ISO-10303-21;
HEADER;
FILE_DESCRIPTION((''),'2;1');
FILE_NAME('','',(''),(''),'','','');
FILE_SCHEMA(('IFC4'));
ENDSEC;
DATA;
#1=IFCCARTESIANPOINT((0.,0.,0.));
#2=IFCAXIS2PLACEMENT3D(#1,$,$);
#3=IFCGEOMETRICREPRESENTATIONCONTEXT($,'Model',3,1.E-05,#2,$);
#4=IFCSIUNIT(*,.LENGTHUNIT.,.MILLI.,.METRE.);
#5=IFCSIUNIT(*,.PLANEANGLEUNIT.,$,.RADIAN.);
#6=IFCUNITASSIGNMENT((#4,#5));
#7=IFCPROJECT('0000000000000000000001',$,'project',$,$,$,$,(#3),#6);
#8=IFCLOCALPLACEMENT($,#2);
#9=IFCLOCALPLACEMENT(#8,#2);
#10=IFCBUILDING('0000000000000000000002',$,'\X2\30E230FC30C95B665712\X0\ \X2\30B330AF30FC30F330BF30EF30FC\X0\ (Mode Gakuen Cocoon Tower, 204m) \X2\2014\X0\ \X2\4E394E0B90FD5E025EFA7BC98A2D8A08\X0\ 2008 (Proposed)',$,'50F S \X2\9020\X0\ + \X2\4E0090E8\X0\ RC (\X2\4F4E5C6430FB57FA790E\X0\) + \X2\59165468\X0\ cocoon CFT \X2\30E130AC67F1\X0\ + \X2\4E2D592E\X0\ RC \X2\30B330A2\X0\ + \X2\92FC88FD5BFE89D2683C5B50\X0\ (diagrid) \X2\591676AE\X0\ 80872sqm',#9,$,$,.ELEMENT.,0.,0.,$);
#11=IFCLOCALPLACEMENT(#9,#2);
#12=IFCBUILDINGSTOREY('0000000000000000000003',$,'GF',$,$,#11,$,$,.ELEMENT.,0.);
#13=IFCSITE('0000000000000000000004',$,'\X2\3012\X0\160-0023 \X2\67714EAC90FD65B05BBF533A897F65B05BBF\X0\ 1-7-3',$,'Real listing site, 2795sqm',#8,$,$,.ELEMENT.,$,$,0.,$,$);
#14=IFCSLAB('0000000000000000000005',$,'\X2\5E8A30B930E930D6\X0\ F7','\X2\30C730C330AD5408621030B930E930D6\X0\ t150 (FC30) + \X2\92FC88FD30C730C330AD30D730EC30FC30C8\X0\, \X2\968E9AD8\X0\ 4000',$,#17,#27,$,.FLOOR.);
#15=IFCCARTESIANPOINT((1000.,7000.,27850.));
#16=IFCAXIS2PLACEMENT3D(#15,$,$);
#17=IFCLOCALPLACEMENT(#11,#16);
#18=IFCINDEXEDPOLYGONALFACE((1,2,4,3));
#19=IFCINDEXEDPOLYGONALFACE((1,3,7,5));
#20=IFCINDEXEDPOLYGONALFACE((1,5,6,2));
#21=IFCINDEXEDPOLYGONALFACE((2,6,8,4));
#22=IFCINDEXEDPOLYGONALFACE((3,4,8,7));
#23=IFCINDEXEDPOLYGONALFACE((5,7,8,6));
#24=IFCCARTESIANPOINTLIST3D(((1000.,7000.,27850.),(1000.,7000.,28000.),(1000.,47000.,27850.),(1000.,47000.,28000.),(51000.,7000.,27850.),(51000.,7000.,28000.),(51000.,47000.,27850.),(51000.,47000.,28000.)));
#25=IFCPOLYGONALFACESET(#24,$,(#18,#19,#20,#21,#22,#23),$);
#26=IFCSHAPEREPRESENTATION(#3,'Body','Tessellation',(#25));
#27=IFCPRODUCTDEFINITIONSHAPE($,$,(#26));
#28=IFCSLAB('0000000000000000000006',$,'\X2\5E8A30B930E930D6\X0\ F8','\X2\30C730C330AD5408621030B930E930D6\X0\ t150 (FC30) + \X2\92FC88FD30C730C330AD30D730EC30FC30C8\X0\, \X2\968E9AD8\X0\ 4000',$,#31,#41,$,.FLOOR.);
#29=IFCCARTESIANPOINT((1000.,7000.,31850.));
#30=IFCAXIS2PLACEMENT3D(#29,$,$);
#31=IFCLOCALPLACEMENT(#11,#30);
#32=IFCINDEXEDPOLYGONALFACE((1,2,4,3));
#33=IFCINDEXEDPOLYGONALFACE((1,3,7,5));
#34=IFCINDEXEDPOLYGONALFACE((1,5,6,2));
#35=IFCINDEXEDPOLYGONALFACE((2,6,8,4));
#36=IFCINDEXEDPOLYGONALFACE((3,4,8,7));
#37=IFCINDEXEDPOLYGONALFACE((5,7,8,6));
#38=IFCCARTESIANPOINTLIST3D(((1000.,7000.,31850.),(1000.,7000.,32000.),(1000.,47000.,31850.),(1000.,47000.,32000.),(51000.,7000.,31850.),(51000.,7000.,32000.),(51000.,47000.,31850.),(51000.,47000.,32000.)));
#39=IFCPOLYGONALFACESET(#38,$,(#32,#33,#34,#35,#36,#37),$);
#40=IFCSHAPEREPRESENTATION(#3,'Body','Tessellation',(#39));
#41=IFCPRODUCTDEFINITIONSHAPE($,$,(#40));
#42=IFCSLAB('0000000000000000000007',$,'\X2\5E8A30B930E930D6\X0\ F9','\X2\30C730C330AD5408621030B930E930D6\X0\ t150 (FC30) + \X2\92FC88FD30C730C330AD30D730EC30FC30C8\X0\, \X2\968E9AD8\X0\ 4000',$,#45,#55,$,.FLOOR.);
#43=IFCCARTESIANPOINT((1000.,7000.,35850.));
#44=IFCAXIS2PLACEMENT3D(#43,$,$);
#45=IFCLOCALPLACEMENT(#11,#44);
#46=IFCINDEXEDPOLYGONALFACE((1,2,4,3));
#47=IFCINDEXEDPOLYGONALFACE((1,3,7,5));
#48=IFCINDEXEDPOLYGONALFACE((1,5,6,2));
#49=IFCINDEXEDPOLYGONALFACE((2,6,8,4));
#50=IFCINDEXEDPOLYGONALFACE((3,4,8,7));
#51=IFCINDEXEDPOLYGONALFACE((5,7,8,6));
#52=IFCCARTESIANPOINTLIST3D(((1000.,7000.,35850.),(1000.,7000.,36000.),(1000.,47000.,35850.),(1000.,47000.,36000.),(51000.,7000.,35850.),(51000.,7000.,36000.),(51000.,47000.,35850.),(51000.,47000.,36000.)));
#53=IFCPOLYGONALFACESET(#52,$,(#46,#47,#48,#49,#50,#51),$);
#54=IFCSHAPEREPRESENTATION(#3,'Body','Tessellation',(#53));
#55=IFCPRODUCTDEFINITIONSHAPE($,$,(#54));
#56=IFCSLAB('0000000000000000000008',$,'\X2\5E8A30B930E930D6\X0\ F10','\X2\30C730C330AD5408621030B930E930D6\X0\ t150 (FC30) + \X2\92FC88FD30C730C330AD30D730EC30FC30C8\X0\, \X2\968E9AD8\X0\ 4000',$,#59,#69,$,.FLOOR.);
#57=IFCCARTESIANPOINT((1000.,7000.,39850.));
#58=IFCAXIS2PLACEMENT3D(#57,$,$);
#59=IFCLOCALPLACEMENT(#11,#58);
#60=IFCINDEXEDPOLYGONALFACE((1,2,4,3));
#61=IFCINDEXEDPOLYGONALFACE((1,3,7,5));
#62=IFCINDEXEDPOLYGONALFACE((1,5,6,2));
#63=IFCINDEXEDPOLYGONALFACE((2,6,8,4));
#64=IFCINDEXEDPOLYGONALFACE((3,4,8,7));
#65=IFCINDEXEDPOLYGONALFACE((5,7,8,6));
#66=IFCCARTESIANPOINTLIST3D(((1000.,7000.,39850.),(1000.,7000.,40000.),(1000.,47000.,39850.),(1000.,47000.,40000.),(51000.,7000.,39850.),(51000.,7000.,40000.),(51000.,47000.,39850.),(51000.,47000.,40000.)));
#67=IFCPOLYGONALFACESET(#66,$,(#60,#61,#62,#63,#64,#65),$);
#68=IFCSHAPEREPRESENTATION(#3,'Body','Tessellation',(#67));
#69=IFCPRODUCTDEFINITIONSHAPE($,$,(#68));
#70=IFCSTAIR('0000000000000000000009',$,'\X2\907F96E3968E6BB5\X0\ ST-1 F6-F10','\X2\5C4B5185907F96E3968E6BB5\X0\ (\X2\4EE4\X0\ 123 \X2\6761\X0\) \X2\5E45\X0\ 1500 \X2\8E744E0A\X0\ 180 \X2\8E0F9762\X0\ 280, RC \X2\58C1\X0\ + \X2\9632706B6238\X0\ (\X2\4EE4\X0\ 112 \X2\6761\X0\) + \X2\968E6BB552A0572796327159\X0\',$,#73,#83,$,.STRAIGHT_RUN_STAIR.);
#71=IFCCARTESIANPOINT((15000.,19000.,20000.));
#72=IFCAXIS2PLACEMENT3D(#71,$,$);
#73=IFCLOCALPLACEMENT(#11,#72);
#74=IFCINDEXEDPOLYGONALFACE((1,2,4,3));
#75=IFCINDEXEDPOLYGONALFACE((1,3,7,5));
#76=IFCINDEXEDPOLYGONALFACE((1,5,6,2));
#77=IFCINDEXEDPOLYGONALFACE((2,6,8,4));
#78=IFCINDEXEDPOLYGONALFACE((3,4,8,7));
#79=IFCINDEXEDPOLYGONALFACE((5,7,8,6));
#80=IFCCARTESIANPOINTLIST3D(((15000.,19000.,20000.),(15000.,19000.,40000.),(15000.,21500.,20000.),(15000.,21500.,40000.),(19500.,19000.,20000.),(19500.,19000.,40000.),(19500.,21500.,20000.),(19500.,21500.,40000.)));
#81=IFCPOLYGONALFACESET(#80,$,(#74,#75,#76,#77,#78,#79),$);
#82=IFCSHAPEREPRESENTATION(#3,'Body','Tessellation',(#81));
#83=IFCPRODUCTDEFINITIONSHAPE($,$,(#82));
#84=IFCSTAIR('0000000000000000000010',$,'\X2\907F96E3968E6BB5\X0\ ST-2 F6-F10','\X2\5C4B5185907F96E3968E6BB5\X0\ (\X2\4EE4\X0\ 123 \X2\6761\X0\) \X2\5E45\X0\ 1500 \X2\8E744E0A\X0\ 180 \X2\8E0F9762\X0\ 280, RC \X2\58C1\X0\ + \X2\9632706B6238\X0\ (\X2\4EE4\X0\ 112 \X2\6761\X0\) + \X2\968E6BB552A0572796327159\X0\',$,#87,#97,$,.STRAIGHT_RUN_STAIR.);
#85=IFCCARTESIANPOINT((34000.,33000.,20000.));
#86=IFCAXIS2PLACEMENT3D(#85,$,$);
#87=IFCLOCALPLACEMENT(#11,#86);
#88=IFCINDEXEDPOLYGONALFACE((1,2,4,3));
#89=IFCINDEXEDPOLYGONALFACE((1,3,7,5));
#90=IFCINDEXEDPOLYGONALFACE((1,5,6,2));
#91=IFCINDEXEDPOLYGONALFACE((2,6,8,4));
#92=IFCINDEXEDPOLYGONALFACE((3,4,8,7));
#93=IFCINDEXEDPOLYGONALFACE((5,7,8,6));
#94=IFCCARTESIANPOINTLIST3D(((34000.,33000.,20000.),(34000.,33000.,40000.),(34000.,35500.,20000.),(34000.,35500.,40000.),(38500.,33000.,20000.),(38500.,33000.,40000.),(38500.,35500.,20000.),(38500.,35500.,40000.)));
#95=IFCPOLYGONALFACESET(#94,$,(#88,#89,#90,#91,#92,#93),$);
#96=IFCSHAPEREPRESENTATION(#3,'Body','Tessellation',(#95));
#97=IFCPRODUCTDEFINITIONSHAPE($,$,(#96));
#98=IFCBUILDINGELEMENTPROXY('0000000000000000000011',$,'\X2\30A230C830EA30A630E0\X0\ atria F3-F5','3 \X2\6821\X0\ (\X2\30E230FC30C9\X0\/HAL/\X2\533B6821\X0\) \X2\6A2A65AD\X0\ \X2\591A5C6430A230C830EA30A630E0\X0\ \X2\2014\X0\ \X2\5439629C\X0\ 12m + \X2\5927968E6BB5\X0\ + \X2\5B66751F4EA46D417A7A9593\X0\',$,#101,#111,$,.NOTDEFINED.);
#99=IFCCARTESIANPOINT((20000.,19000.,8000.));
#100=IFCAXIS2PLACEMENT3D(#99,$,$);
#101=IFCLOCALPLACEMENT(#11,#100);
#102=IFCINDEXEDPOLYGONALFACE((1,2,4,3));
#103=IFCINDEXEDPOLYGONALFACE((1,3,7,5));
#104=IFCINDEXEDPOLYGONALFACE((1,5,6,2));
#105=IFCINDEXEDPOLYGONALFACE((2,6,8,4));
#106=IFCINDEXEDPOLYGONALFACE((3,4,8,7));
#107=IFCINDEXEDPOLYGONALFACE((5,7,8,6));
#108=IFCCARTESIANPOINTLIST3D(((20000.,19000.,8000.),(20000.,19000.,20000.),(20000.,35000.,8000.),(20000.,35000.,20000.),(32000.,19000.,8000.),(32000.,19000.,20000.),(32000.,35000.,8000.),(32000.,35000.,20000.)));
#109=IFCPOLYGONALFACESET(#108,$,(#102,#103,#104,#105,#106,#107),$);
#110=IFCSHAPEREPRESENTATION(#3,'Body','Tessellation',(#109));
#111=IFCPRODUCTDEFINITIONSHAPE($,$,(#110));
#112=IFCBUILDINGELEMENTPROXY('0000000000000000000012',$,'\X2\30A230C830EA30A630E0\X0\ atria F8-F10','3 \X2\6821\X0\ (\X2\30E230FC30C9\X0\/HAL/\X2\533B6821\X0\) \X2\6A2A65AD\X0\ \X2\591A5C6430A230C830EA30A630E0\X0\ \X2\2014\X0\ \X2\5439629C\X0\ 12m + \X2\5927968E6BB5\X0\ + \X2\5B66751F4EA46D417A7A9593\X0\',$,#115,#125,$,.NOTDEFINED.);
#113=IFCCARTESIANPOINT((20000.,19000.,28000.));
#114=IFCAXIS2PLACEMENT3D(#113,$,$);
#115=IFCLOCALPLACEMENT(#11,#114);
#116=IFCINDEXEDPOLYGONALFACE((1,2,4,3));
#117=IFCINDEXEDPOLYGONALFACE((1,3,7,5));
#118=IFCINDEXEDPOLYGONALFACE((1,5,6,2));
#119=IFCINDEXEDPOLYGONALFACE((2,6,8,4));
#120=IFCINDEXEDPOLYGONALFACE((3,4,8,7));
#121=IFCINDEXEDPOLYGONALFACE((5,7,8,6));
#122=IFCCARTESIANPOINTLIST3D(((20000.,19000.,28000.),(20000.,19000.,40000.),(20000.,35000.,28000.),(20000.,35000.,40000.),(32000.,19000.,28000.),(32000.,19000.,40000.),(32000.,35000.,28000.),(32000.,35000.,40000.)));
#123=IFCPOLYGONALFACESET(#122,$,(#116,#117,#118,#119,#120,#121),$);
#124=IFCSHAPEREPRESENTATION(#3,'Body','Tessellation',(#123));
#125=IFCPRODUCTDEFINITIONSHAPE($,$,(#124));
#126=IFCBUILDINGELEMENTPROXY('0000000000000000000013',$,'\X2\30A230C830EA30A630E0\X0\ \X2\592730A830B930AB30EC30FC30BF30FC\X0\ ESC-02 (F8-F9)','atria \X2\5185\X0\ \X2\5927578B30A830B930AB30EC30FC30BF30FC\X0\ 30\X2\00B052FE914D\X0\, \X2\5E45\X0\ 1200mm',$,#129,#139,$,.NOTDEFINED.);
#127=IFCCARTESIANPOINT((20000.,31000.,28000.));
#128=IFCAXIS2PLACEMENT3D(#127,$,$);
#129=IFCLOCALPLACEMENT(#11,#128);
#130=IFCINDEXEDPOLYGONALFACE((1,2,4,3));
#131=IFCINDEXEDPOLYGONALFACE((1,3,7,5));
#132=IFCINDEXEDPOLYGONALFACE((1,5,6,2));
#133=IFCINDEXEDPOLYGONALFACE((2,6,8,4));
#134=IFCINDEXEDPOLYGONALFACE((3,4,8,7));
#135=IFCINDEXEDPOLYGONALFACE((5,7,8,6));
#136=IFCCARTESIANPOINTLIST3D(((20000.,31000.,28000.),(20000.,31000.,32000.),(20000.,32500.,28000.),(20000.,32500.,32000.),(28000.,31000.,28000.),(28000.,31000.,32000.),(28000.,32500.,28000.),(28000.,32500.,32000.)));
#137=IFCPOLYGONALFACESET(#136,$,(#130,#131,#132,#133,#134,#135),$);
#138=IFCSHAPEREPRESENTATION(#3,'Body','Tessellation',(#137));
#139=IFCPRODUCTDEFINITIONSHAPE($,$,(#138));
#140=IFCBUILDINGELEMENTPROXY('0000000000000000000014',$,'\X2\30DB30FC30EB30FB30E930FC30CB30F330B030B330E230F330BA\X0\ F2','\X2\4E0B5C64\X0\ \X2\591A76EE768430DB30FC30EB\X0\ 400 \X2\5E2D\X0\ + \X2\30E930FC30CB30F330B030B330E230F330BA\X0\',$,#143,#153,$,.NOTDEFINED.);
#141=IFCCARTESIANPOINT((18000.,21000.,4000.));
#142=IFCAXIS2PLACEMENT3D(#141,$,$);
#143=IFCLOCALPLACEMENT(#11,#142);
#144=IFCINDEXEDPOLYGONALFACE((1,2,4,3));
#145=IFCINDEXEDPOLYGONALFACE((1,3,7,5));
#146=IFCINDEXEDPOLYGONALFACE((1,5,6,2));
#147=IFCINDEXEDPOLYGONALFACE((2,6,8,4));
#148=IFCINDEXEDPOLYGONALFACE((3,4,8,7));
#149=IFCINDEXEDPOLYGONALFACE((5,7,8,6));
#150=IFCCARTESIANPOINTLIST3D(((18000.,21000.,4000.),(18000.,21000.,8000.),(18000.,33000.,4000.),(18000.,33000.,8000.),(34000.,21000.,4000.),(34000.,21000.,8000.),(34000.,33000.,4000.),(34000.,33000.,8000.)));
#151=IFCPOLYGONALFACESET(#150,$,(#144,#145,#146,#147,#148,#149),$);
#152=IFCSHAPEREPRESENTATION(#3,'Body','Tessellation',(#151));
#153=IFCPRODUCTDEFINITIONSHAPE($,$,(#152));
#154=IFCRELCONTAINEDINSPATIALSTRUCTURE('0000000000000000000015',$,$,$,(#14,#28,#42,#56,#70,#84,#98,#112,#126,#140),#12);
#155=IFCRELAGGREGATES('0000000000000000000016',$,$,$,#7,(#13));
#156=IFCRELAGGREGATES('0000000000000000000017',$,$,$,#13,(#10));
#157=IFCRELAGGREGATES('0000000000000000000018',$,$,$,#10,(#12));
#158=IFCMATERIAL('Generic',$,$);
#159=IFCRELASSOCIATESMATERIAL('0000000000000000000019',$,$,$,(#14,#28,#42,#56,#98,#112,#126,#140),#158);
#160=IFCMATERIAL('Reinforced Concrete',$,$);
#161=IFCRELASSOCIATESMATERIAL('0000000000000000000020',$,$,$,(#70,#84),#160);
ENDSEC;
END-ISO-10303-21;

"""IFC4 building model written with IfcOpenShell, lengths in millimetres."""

from ifc_helpers import new_model, si_unit, frame, frame_2d, origin, place, context, project, spatial, rectangle, extrude, material, element, save


model = new_model("IFC4")

# Units and contexts
model_context = context("Model", 3, precision=1e-05, world=origin())
ifc_project = project(units=[si_unit("LENGTHUNIT", "METRE", prefix="MILLI"), si_unit("PLANEANGLEUNIT", "RADIAN")], contexts=[model_context])

# Site, building, storey
site_placement = place(None, origin())
site = spatial("IfcSite", under=ifc_project, at=site_placement, Name="〒160-0023 東京都新宿区西新宿 1-7-3", ObjectType="Real listing site, 2795sqm", CompositionType="ELEMENT", RefElevation=0.0)
building_placement = place(site_placement, origin())
building = spatial("IfcBuilding", under=site, at=building_placement, Name="モード学園 コクーンタワー (Mode Gakuen Cocoon Tower, 204m) — 丹下都市建築設計 2008 (Proposed)", ObjectType="50F S 造 + 一部 RC (低層・基礎) + 外周 cocoon CFT メガ柱 + 中央 RC コア + 鋼製対角格子 (diagrid) 外皮 80872sqm", CompositionType="ELEMENT", ElevationOfRefHeight=0.0, ElevationOfTerrain=0.0)
storey_placement = place(building_placement, origin())
storey = spatial("IfcBuildingStorey", under=building, at=storey_placement, Name="GF", CompositionType="ELEMENT", Elevation=0.0)

# Shared definitions
ifc_material_1 = material(Name="Generic")

# Slabs
slab_1_placement = place(storey_placement, frame((1000.0, 7000.0, 27850.0)))
element("IfcSlab", 1, at=slab_1_placement, inside=storey, material=ifc_material_1, Name="床スラブ F7", Description="デッキ合成スラブ t150 (FC30) + 鋼製デッキプレート, 階高 4000", PredefinedType="FLOOR", context=model_context, shape_type="SweptSolid", body=[
    extrude(rectangle(XDim=50000.0, YDim=40000.0, at=frame_2d((25000.0, 20000.0))), frame((1000.0, 7000.0, 27850.0)), (0.0, 0.0, 1.0), 150.0),
])
slab_2_placement = place(storey_placement, frame((1000.0, 7000.0, 31850.0)))
element("IfcSlab", 2, at=slab_2_placement, inside=storey, material=ifc_material_1, Name="床スラブ F8", Description="デッキ合成スラブ t150 (FC30) + 鋼製デッキプレート, 階高 4000", PredefinedType="FLOOR", context=model_context, shape_type="SweptSolid", body=[
    extrude(rectangle(XDim=50000.0, YDim=40000.0, at=frame_2d((25000.0, 20000.0))), frame((1000.0, 7000.0, 31850.0)), (0.0, 0.0, 1.0), 150.0),
])
slab_3_placement = place(storey_placement, frame((1000.0, 7000.0, 35850.0)))
element("IfcSlab", 3, at=slab_3_placement, inside=storey, material=ifc_material_1, Name="床スラブ F9", Description="デッキ合成スラブ t150 (FC30) + 鋼製デッキプレート, 階高 4000", PredefinedType="FLOOR", context=model_context, shape_type="SweptSolid", body=[
    extrude(rectangle(XDim=50000.0, YDim=40000.0, at=frame_2d((25000.0, 20000.0))), frame((1000.0, 7000.0, 35850.0)), (0.0, 0.0, 1.0), 150.0),
])
slab_4_placement = place(storey_placement, frame((1000.0, 7000.0, 39850.0)))
element("IfcSlab", 4, at=slab_4_placement, inside=storey, material=ifc_material_1, Name="床スラブ F10", Description="デッキ合成スラブ t150 (FC30) + 鋼製デッキプレート, 階高 4000", PredefinedType="FLOOR", context=model_context, shape_type="SweptSolid", body=[
    extrude(rectangle(XDim=50000.0, YDim=40000.0, at=frame_2d((25000.0, 20000.0))), frame((1000.0, 7000.0, 39850.0)), (0.0, 0.0, 1.0), 150.0),
])

# Stairs
ifc_material_2 = material(Name="Reinforced Concrete")
stair_1_placement = place(storey_placement, frame((15000.0, 19000.0, 20000.0)))
element("IfcStair", 5, at=stair_1_placement, inside=storey, material=ifc_material_2, Name="避難階段 ST-1 F6-F10", Description="屋内避難階段 (令 123 条) 幅 1500 蹴上 180 踏面 280, RC 壁 + 防火戸 (令 112 条) + 階段加圧防煙", PredefinedType="STRAIGHT_RUN_STAIR", context=model_context, shape_type="SweptSolid", body=[
    extrude(rectangle(XDim=4500.0, YDim=2500.0, at=frame_2d((2250.0, 1250.0))), frame((15000.0, 19000.0, 20000.0)), (0.0, 0.0, 1.0), 20000.0),
])
stair_2_placement = place(storey_placement, frame((34000.0, 33000.0, 20000.0)))
element("IfcStair", 6, at=stair_2_placement, inside=storey, material=ifc_material_2, Name="避難階段 ST-2 F6-F10", Description="屋内避難階段 (令 123 条) 幅 1500 蹴上 180 踏面 280, RC 壁 + 防火戸 (令 112 条) + 階段加圧防煙", PredefinedType="STRAIGHT_RUN_STAIR", context=model_context, shape_type="SweptSolid", body=[
    extrude(rectangle(XDim=4500.0, YDim=2500.0, at=frame_2d((2250.0, 1250.0))), frame((34000.0, 33000.0, 20000.0)), (0.0, 0.0, 1.0), 20000.0),
])

# Building element proxies
proxy_1_placement = place(storey_placement, frame((20000.0, 19000.0, 8000.0)))
element("IfcBuildingElementProxy", 7, at=proxy_1_placement, inside=storey, material=ifc_material_1, Name="アトリウム atria F3-F5", Description="3 校 (モード/HAL/医校) 横断 多層アトリウム — 吹抜 12m + 大階段 + 学生交流空間", PredefinedType="NOTDEFINED", context=model_context, shape_type="SweptSolid", body=[
    extrude(rectangle(XDim=12000.0, YDim=16000.0, at=frame_2d((6000.0, 8000.0))), frame((20000.0, 19000.0, 8000.0)), (0.0, 0.0, 1.0), 12000.0),
])
proxy_2_placement = place(storey_placement, frame((20000.0, 19000.0, 28000.0)))
element("IfcBuildingElementProxy", 8, at=proxy_2_placement, inside=storey, material=ifc_material_1, Name="アトリウム atria F8-F10", Description="3 校 (モード/HAL/医校) 横断 多層アトリウム — 吹抜 12m + 大階段 + 学生交流空間", PredefinedType="NOTDEFINED", context=model_context, shape_type="SweptSolid", body=[
    extrude(rectangle(XDim=12000.0, YDim=16000.0, at=frame_2d((6000.0, 8000.0))), frame((20000.0, 19000.0, 28000.0)), (0.0, 0.0, 1.0), 12000.0),
])
proxy_3_placement = place(storey_placement, frame((20000.0, 31000.0, 28000.0)))
element("IfcBuildingElementProxy", 9, at=proxy_3_placement, inside=storey, material=ifc_material_1, Name="アトリウム 大エスカレーター ESC-02 (F8-F9)", Description="atria 内 大型エスカレーター 30°勾配, 幅 1200mm", PredefinedType="NOTDEFINED", context=model_context, shape_type="SweptSolid", body=[
    extrude(rectangle(XDim=8000.0, YDim=1500.0, at=frame_2d((4000.0, 750.0))), frame((20000.0, 31000.0, 28000.0)), (0.0, 0.0, 1.0), 4000.0),
])
proxy_4_placement = place(storey_placement, frame((18000.0, 21000.0, 4000.0)))
element("IfcBuildingElementProxy", 10, at=proxy_4_placement, inside=storey, material=ifc_material_1, Name="ホール・ラーニングコモンズ F2", Description="下層 多目的ホール 400 席 + ラーニングコモンズ", PredefinedType="NOTDEFINED", context=model_context, shape_type="SweptSolid", body=[
    extrude(rectangle(XDim=16000.0, YDim=12000.0, at=frame_2d((8000.0, 6000.0))), frame((18000.0, 21000.0, 4000.0)), (0.0, 0.0, 1.0), 4000.0),
])

save(model, "model.ifc")
